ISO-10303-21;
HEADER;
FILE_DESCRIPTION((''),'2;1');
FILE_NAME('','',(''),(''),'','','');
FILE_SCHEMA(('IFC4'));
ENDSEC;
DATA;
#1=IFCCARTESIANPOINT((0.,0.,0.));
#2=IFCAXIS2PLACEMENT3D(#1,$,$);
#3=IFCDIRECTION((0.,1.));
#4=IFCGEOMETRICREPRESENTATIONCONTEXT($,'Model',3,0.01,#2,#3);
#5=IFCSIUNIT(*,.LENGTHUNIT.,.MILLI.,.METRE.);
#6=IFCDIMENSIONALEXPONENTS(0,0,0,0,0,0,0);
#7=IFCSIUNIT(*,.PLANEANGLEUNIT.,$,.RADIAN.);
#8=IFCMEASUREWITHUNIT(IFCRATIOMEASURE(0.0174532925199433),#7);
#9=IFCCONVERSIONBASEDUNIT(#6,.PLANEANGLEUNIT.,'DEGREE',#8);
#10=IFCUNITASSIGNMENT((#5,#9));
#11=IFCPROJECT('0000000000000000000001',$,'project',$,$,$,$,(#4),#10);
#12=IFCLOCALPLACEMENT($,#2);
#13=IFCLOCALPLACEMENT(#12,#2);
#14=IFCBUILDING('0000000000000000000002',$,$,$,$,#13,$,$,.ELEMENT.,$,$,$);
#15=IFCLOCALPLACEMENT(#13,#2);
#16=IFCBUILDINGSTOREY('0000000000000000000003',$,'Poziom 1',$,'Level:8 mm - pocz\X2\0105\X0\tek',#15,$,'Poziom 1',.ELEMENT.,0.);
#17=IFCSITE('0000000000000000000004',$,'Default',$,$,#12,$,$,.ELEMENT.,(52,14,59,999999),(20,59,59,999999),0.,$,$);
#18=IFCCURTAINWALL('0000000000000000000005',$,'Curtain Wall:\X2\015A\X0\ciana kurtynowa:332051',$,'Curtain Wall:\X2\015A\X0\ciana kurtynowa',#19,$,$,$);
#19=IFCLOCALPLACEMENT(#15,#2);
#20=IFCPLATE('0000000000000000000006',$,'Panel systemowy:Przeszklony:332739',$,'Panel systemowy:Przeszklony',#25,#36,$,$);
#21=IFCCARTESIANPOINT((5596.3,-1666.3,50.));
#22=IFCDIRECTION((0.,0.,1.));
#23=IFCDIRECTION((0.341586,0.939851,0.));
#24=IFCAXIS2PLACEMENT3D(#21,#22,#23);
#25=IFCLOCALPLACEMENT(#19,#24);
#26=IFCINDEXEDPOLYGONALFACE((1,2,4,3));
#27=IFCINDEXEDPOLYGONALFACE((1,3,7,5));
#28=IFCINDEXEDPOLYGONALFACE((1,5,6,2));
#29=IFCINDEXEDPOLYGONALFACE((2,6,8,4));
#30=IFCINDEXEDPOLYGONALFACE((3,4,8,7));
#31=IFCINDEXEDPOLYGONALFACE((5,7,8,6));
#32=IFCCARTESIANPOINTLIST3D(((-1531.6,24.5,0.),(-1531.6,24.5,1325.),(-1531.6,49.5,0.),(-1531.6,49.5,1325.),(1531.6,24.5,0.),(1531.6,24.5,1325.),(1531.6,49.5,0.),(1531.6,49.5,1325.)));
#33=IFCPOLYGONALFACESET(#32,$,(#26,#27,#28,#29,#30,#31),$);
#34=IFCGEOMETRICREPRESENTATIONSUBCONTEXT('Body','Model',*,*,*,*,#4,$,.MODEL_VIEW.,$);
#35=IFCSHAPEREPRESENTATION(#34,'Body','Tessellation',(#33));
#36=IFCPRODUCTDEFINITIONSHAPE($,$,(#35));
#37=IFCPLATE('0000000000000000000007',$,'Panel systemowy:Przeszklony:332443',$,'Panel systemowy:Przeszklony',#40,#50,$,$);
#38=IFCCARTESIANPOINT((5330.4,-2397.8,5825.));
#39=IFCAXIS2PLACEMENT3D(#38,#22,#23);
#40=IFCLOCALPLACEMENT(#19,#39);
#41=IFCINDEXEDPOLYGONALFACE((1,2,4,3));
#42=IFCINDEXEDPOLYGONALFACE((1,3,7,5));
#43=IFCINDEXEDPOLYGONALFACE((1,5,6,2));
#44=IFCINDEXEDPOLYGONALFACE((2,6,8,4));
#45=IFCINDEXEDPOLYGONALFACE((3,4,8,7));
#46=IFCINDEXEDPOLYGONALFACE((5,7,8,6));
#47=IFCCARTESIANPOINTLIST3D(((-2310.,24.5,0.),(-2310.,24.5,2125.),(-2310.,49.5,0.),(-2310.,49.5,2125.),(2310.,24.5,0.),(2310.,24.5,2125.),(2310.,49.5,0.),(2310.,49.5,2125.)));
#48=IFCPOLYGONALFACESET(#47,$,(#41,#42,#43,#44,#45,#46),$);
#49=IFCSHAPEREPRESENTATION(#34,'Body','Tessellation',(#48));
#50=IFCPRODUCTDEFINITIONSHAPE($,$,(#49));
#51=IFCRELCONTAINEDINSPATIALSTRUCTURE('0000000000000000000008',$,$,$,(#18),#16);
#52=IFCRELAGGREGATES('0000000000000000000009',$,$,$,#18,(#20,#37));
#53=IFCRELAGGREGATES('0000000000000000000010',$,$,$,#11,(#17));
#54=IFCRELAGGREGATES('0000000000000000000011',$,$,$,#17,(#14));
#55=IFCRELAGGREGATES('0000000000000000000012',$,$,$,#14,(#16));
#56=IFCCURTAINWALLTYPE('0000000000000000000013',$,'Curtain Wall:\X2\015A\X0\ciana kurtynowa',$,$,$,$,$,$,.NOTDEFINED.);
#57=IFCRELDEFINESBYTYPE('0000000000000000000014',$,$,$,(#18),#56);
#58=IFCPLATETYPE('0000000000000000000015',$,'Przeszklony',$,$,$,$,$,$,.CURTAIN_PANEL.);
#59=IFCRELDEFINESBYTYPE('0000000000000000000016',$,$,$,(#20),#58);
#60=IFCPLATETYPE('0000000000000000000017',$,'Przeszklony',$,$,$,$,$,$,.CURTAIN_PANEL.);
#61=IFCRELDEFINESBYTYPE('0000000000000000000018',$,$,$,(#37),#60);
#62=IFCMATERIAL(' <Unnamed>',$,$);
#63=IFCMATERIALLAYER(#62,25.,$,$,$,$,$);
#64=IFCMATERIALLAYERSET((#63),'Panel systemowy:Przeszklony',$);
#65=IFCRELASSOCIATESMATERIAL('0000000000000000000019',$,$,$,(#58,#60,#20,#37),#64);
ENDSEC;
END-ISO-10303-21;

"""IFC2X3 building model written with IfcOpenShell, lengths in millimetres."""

from ifc_helpers import new_model, entity, si_unit, converted_unit, direction, frame, frame_2d, origin, place, context, subcontext, project, spatial, rectangle, extrude, source, transform, mapped, material, layer, layer_set, layer_usage, type_object, type_shapes, element, aggregate, save


model = new_model("IFC2X3")

# Units and contexts
model_context = context("Model", 3, precision=0.01, world=origin(), true_north=direction((0.0, 1.0)))
body_context = subcontext(model_context, "Body", "Model", "MODEL_VIEW")
ifc_project = project(units=[si_unit("LENGTHUNIT", "METRE", prefix="MILLI"), converted_unit("PLANEANGLEUNIT", "DEGREE", entity("IfcRatioMeasure", 0.0174532925199433), si_unit("PLANEANGLEUNIT", "RADIAN"), dimensions=[0, 0, 0, 0, 0, 0, 0])], contexts=[model_context])

# Site, building, storey
site_placement = place(None, origin())
site = spatial("IfcSite", under=ifc_project, at=site_placement, Name="Default", CompositionType="ELEMENT", RefLatitude=(52, 14, 59, 999999), RefLongitude=(20, 59, 59, 999999), RefElevation=0.0)
building_placement = place(site_placement, origin())
building = spatial("IfcBuilding", under=site, at=building_placement, CompositionType="ELEMENT")
storey_placement = place(building_placement, origin())
storey = spatial("IfcBuildingStorey", under=building, at=storey_placement, Name="Poziom 1", ObjectType="Level:8 mm - początek", LongName="Poziom 1", CompositionType="ELEMENT", Elevation=0.0)

# Curtain wall
curtain_wall_type = type_object("IfcCurtainWallType", Name="Curtain Wall:Ściana kurtynowa", PredefinedType="NOTDEFINED")
curtain_wall_placement = place(storey_placement, origin())
curtain_wall = element("IfcCurtainWall", 1, at=curtain_wall_placement, inside=storey, type_object=curtain_wall_type, Name="Curtain Wall:Ściana kurtynowa:332051", ObjectType="Curtain Wall:Ściana kurtynowa")

# Plates
ifc_material_1 = material(Name=" <Unnamed>")
ifc_layer_1 = layer(ifc_material_1, 25.0)
ifc_layer_set_1 = layer_set([ifc_layer_1], Name="Panel systemowy:Przeszklony")
ifc_layer_usage_1 = layer_usage(ifc_layer_set_1, "AXIS3", "POSITIVE", 0.1)
plate_type_1 = type_object("IfcPlateType", Name="Przeszklony", PredefinedType="CURTAIN_PANEL", material=ifc_layer_set_1)
shared_shape_1 = source(origin(), body_context, "Body", "SweptSolid", [
    extrude(rectangle(XDim=1325.0, YDim=3063.3, at=frame_2d((0.0, -194.6), x_axis=(1.0, 0.0))), frame((194.6, 24.5, 662.5), z_axis=(0.0, 1.0, 0.0), x_axis=(0.0, 0.0, 1.0)), (0.0, 0.0, 1.0), 25.0),
])
type_shapes(plate_type_1, [shared_shape_1])
plate_1_placement = place(curtain_wall_placement, frame((5596.3, -1666.3, 50.0), z_axis=(0.0, 0.0, 1.0), x_axis=(0.341586, 0.939851, 0.0)))
plate_1 = element("IfcPlate", 2, at=plate_1_placement, type_object=plate_type_1, material=ifc_layer_usage_1, Name="Panel systemowy:Przeszklony:332739", ObjectType="Panel systemowy:Przeszklony", context=body_context, shape_type="MappedRepresentation", body=[
    mapped(shared_shape_1, transform((0.0, 0.0, 0.0), scale=1.0)),
])
ifc_layer_usage_2 = layer_usage(ifc_layer_set_1, "AXIS3", "POSITIVE", 0.1)
plate_type_2 = type_object("IfcPlateType", Name="Przeszklony", PredefinedType="CURTAIN_PANEL", material=ifc_layer_set_1)
shared_shape_2 = source(origin(), body_context, "Body", "SweptSolid", [
    extrude(rectangle(XDim=2125.0, YDim=4619.9, at=frame_2d((0.0, -311.3), x_axis=(1.0, 0.0))), frame((311.3, 24.5, 1062.5), z_axis=(0.0, 1.0, 0.0), x_axis=(0.0, 0.0, 1.0)), (0.0, 0.0, 1.0), 25.0),
])
type_shapes(plate_type_2, [shared_shape_2])
plate_2_placement = place(curtain_wall_placement, frame((5330.4, -2397.8, 5825.0), z_axis=(0.0, 0.0, 1.0), x_axis=(0.341586, 0.939851, 0.0)))
plate_2 = element("IfcPlate", 3, at=plate_2_placement, type_object=plate_type_2, material=ifc_layer_usage_2, Name="Panel systemowy:Przeszklony:332443", ObjectType="Panel systemowy:Przeszklony", context=body_context, shape_type="MappedRepresentation", body=[
    mapped(shared_shape_2, transform((0.0, 0.0, 0.0), scale=1.0)),
])
aggregate(curtain_wall, [plate_1, plate_2])

save(model, "model.ifc")
